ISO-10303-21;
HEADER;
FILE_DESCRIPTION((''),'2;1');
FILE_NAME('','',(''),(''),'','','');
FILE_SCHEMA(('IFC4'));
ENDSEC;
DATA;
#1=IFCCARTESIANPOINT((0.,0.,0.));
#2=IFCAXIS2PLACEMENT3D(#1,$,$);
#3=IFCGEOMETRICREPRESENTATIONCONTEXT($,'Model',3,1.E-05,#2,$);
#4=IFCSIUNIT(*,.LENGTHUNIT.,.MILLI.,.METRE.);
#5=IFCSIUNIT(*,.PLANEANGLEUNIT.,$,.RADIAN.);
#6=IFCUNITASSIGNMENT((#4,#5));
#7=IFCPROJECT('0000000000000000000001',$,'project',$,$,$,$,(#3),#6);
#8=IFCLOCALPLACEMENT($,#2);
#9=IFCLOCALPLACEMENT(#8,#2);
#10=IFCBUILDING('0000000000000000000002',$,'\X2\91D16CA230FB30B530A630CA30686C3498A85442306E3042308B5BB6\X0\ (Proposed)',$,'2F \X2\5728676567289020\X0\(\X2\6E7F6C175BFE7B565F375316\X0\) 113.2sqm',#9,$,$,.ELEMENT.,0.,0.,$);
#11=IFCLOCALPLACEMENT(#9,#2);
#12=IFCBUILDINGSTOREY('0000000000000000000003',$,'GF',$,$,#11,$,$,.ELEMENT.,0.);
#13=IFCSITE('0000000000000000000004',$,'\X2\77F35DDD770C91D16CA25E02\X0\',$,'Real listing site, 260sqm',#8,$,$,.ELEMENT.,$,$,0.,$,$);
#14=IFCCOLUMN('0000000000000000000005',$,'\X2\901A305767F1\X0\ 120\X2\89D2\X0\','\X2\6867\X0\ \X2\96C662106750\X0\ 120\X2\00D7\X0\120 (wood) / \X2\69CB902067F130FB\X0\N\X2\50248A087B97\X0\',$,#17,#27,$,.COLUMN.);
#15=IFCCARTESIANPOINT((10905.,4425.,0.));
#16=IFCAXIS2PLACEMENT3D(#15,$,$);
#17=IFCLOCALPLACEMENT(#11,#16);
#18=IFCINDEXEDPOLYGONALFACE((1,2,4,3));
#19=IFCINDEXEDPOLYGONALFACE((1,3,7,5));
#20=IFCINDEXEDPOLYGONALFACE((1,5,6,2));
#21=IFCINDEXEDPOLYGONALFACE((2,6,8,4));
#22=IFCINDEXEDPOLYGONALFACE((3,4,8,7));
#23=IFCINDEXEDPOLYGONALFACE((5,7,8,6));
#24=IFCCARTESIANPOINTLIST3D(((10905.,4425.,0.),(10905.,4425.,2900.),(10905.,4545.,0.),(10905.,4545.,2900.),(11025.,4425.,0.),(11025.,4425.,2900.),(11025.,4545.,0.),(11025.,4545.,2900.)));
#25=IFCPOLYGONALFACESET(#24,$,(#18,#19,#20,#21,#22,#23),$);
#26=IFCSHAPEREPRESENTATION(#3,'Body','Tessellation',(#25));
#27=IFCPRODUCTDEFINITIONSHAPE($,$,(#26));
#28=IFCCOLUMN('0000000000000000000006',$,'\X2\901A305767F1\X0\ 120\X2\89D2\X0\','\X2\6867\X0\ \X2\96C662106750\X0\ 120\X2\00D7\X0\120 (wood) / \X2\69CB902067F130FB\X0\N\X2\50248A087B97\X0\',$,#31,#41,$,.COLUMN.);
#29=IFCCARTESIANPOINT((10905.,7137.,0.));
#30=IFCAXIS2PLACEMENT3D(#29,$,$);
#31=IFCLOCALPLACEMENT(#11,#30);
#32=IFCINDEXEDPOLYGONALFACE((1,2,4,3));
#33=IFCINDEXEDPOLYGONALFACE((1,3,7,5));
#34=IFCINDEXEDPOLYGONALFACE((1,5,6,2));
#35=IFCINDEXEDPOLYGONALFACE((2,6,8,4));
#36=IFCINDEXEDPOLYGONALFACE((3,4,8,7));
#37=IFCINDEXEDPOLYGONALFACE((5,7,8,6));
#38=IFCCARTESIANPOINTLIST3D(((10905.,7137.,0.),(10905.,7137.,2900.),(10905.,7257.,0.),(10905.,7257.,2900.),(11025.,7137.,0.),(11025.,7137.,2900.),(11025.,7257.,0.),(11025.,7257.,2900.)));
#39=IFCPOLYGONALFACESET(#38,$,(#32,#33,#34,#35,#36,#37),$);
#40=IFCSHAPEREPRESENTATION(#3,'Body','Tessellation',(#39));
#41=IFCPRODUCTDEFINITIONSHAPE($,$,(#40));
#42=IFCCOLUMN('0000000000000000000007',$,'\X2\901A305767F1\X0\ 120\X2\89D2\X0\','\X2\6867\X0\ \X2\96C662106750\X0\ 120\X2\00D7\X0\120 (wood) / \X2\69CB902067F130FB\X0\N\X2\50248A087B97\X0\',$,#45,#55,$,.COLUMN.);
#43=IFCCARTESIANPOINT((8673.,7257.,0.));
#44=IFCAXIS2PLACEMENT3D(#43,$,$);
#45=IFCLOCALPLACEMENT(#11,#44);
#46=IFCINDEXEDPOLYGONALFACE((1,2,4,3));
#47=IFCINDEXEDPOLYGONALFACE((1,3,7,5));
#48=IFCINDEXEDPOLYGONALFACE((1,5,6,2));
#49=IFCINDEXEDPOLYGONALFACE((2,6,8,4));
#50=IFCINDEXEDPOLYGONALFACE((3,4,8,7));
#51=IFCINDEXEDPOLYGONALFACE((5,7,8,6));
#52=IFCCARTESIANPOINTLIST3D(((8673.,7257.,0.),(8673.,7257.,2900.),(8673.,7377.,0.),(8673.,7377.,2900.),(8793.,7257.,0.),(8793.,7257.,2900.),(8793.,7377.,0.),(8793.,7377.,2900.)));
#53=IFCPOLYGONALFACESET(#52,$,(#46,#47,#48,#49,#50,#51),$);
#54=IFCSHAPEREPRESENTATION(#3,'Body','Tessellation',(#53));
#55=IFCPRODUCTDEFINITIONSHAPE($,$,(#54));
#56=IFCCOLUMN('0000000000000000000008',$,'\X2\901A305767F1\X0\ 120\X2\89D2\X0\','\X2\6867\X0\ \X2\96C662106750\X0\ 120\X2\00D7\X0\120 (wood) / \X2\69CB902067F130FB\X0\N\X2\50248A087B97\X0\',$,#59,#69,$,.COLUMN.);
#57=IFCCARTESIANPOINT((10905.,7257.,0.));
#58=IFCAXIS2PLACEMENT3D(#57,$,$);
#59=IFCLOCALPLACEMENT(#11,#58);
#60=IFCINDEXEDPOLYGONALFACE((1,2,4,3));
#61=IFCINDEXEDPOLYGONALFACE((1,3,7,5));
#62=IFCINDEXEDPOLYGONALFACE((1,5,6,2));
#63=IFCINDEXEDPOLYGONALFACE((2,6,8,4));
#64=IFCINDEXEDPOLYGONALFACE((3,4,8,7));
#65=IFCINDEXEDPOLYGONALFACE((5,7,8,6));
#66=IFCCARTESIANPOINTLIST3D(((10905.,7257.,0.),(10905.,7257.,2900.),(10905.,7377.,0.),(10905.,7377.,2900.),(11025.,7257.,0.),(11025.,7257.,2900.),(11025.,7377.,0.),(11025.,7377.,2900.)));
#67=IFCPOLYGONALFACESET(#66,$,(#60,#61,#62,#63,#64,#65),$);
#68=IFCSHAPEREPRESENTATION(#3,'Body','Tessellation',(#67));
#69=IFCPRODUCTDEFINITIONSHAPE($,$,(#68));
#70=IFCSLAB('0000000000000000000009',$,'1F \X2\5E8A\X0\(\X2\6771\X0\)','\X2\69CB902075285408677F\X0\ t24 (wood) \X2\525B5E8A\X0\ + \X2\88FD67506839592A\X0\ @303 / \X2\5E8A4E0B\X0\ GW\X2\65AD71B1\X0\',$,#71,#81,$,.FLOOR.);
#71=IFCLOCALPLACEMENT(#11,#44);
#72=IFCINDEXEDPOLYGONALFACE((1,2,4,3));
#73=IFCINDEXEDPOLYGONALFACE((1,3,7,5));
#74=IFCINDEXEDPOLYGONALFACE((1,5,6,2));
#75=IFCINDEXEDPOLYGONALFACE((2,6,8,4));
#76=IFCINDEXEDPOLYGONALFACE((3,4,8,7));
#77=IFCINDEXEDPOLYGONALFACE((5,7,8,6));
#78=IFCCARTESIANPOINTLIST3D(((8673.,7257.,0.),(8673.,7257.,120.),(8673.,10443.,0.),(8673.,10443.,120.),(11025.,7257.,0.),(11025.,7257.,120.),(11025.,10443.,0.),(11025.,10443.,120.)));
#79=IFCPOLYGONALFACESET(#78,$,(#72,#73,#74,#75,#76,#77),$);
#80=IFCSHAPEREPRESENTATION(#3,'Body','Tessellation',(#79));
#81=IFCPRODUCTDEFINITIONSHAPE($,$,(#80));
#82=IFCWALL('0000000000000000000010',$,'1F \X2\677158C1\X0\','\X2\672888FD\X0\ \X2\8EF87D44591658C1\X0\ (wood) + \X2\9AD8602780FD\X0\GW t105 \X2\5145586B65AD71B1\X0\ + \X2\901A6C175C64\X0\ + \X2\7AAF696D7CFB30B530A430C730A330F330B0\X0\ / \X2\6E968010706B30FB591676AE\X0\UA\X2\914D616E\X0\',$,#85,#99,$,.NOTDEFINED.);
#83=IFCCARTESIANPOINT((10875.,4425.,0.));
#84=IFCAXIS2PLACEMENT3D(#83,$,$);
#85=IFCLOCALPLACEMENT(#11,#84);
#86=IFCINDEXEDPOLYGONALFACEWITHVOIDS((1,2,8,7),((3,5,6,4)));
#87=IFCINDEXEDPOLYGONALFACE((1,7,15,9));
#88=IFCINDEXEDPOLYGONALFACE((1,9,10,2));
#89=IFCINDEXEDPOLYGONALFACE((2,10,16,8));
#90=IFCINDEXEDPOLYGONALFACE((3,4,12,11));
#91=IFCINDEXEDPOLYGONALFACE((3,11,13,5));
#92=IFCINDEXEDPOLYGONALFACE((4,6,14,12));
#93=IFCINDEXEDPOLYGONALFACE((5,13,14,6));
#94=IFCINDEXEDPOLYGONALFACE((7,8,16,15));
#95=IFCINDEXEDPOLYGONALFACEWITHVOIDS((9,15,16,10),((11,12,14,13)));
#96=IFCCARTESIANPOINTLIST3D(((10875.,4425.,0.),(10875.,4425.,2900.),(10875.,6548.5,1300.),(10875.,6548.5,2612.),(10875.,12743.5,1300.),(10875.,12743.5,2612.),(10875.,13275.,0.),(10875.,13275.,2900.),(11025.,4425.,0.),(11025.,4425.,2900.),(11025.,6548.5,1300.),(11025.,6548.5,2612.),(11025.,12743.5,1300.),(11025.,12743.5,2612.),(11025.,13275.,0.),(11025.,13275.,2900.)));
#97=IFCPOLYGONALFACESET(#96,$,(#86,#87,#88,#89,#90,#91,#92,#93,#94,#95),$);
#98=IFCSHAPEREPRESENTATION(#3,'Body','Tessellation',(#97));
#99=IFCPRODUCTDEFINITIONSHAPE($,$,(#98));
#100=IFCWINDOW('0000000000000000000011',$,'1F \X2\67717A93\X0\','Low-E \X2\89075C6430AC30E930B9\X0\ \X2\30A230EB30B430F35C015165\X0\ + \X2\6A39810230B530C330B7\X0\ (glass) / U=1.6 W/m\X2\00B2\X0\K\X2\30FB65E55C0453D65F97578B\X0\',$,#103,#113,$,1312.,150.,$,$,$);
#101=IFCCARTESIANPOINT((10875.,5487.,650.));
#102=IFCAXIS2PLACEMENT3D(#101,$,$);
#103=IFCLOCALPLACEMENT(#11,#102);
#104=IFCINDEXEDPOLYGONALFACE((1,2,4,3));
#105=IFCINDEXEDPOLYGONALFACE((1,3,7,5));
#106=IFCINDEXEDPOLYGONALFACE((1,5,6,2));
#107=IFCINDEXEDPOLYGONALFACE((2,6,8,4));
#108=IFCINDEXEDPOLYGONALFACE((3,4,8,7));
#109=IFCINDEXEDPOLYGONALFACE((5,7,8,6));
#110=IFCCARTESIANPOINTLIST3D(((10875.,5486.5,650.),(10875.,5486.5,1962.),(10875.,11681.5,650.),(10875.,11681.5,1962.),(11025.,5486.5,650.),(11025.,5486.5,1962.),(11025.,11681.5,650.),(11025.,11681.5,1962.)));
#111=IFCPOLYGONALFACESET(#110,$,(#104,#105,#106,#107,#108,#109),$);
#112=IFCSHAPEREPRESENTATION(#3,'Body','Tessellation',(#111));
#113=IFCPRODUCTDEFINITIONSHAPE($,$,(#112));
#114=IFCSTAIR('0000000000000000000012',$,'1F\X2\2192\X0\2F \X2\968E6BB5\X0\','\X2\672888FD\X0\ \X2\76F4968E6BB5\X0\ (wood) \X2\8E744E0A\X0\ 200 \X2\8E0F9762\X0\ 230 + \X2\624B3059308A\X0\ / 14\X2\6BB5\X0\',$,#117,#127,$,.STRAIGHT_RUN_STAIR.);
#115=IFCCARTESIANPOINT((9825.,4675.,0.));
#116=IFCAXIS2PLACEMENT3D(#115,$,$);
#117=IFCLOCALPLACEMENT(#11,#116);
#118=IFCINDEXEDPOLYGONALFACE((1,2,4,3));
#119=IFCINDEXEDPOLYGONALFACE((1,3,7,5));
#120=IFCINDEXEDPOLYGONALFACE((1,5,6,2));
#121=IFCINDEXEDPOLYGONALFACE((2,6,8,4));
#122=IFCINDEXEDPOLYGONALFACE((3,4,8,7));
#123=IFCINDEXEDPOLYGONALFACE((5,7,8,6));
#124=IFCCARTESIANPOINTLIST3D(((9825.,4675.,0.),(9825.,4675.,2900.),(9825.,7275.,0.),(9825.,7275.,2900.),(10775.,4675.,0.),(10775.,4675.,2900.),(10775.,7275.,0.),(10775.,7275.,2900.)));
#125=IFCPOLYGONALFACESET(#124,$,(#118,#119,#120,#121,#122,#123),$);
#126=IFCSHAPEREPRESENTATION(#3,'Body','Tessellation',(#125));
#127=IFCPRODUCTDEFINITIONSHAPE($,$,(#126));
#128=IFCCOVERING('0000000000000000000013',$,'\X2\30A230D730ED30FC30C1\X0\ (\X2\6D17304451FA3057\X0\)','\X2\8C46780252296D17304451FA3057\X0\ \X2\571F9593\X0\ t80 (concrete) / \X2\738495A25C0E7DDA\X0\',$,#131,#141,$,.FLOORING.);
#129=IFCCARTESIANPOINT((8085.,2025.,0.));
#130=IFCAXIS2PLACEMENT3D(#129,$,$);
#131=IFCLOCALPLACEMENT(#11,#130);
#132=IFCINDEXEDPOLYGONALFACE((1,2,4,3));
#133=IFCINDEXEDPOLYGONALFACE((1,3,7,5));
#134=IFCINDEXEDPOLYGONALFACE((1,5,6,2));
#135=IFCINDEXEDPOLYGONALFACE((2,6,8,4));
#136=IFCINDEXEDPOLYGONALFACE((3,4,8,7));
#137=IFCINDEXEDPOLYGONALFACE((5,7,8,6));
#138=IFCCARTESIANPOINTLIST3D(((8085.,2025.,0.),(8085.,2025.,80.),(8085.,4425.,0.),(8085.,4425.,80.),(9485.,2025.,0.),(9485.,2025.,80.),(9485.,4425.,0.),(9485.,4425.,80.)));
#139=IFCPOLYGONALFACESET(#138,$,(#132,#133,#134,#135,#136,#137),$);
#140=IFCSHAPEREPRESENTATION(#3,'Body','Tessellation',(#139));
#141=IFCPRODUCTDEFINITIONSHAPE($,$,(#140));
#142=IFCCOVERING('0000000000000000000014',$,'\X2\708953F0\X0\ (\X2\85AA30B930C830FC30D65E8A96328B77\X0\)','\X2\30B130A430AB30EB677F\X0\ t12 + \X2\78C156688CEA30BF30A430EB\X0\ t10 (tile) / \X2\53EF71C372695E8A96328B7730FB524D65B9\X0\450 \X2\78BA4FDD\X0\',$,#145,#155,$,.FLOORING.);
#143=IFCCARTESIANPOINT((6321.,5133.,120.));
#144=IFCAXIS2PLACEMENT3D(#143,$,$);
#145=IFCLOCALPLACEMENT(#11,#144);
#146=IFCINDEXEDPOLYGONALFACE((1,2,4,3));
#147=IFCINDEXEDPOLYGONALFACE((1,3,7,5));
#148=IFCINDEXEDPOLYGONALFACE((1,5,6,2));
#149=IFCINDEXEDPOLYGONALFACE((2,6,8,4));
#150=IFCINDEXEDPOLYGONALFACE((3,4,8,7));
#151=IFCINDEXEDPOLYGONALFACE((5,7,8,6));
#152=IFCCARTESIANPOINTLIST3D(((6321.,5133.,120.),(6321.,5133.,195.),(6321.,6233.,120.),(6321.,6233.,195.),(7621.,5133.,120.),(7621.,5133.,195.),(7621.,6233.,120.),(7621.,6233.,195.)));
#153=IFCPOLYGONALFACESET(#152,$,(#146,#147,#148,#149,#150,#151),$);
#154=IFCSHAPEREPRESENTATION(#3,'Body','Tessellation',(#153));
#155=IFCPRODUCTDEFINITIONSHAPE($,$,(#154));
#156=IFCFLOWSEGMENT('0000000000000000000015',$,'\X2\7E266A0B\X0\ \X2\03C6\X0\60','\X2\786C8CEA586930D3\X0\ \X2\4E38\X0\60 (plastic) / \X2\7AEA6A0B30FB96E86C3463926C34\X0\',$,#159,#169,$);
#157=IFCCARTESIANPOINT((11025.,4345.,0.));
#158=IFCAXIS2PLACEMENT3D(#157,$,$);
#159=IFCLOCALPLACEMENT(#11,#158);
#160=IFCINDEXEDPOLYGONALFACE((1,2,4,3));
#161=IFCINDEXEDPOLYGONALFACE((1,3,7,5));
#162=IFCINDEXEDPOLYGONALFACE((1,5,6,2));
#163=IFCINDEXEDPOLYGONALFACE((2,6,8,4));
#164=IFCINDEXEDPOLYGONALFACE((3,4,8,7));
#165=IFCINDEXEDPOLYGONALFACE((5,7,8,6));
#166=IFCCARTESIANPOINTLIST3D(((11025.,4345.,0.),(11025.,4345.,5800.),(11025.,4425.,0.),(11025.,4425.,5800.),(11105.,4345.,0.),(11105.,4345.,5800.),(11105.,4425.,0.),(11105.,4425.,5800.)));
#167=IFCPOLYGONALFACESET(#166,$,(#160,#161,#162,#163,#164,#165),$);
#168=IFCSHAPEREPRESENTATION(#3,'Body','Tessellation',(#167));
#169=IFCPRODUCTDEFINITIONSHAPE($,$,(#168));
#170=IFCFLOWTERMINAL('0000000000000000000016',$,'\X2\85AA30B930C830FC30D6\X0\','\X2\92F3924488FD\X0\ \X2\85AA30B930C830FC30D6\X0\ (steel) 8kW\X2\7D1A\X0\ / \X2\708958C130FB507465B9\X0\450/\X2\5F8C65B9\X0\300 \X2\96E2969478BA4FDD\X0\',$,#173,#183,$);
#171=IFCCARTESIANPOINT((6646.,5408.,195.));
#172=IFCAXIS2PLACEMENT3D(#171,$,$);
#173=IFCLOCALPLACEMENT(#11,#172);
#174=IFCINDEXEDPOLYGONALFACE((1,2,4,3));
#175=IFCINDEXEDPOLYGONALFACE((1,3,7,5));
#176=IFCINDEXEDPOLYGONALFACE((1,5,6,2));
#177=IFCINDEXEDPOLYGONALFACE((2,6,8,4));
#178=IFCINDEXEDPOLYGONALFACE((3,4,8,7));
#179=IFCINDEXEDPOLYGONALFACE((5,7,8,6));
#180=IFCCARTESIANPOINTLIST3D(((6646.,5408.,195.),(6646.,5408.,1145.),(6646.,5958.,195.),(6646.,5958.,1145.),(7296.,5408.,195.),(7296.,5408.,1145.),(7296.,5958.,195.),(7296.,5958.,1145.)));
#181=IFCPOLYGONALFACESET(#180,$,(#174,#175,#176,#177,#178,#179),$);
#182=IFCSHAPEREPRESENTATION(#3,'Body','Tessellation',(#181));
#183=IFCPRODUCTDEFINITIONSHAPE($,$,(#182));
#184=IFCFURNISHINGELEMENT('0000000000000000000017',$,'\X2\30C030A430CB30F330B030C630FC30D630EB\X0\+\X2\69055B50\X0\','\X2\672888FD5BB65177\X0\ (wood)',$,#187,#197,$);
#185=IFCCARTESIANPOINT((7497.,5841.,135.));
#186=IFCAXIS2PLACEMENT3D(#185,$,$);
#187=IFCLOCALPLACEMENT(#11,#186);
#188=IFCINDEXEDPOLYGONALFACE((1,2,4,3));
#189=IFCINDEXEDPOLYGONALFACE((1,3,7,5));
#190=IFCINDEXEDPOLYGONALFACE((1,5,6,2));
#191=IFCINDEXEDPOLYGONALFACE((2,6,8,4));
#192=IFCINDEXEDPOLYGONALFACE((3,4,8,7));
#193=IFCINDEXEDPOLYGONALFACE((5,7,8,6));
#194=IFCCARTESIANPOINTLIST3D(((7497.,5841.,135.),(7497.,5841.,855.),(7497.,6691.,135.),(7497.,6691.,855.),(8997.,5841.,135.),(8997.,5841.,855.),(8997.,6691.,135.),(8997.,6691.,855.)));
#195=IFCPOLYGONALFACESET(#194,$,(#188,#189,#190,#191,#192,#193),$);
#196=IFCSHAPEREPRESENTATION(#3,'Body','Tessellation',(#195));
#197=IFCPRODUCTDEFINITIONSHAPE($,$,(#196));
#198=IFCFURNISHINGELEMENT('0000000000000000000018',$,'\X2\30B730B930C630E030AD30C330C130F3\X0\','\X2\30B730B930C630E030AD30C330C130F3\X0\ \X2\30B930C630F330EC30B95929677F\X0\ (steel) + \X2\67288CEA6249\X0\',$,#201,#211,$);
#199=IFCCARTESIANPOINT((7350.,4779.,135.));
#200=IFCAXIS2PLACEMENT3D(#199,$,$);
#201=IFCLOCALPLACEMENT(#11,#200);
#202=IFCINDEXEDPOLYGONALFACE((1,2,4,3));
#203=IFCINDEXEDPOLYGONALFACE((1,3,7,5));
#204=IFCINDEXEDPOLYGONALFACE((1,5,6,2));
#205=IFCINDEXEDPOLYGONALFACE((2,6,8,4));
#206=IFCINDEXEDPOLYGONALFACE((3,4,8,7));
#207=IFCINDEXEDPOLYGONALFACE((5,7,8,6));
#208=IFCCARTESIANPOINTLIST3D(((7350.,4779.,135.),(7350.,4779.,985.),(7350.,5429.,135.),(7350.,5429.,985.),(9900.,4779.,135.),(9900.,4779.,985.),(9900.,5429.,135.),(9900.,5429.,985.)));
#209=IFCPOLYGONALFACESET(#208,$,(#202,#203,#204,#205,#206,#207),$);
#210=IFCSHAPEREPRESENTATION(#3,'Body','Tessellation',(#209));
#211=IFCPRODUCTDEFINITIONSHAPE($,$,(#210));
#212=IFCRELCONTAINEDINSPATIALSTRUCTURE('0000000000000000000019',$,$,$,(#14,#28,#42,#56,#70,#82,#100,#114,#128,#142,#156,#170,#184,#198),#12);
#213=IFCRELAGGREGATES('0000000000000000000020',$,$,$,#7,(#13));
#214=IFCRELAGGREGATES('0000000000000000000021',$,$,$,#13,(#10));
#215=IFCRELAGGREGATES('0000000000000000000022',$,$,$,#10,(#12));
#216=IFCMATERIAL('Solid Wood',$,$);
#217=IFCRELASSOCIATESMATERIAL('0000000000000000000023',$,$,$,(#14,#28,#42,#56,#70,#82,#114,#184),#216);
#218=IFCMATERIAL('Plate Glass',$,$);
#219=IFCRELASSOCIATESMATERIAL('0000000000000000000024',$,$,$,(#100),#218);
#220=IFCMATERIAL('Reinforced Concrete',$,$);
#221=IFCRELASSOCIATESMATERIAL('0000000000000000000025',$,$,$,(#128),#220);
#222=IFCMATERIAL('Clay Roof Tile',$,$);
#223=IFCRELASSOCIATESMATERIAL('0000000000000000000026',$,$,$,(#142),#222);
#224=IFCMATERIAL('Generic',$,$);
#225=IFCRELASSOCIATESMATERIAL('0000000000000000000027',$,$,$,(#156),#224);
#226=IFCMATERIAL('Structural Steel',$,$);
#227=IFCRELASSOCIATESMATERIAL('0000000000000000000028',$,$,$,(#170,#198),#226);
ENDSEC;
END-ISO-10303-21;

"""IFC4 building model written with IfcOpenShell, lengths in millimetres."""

from ifc_helpers import new_model, si_unit, frame, frame_2d, origin, place, context, project, spatial, rectangle, extrude, material, element, fill, save


model = new_model("IFC4")

# Units and contexts
model_context = context("Model", 3, precision=1e-05, world=origin())
ifc_project = project(units=[si_unit("LENGTHUNIT", "METRE", prefix="MILLI"), si_unit("PLANEANGLEUNIT", "RADIAN")], contexts=[model_context])

# Site, building, storey
site_placement = place(None, origin())
site = spatial("IfcSite", under=ifc_project, at=site_placement, Name="石川県金沢市", ObjectType="Real listing site, 260sqm", CompositionType="ELEMENT", RefElevation=0.0)
building_placement = place(site_placement, origin())
building = spatial("IfcBuilding", under=site, at=building_placement, Name="金沢・サウナと水風呂のある家 (Proposed)", ObjectType="2F 在来木造(湿気対策強化) 113.2sqm", CompositionType="ELEMENT", ElevationOfRefHeight=0.0, ElevationOfTerrain=0.0)
storey_placement = place(building_placement, origin())
storey = spatial("IfcBuildingStorey", under=building, at=storey_placement, Name="GF", CompositionType="ELEMENT", Elevation=0.0)

# Columns
ifc_material_1 = material(Name="Solid Wood")
column_1_placement = place(storey_placement, frame((10905.0, 4425.0, 0.0)))
element("IfcColumn", 1, at=column_1_placement, inside=storey, material=ifc_material_1, Name="通し柱 120角", Description="桧 集成材 120×120 (wood) / 構造柱・N値計算", PredefinedType="COLUMN", context=model_context, shape_type="SweptSolid", body=[
    extrude(rectangle(XDim=120.0, YDim=120.0, at=frame_2d((60.0, 60.0))), frame((10905.0, 4425.0, 0.0)), (0.0, 0.0, 1.0), 2900.0),
])
column_2_placement = place(storey_placement, frame((10905.0, 7137.0, 0.0)))
element("IfcColumn", 2, at=column_2_placement, inside=storey, material=ifc_material_1, Name="通し柱 120角", Description="桧 集成材 120×120 (wood) / 構造柱・N値計算", PredefinedType="COLUMN", context=model_context, shape_type="SweptSolid", body=[
    extrude(rectangle(XDim=120.0, YDim=120.0, at=frame_2d((60.0, 60.0))), frame((10905.0, 7137.0, 0.0)), (0.0, 0.0, 1.0), 2900.0),
])
column_3_placement = place(storey_placement, frame((8673.0, 7257.0, 0.0)))
element("IfcColumn", 3, at=column_3_placement, inside=storey, material=ifc_material_1, Name="通し柱 120角", Description="桧 集成材 120×120 (wood) / 構造柱・N値計算", PredefinedType="COLUMN", context=model_context, shape_type="SweptSolid", body=[
    extrude(rectangle(XDim=120.0, YDim=120.0, at=frame_2d((60.0, 60.0))), frame((8673.0, 7257.0, 0.0)), (0.0, 0.0, 1.0), 2900.0),
])
column_4_placement = place(storey_placement, frame((10905.0, 7257.0, 0.0)))
element("IfcColumn", 4, at=column_4_placement, inside=storey, material=ifc_material_1, Name="通し柱 120角", Description="桧 集成材 120×120 (wood) / 構造柱・N値計算", PredefinedType="COLUMN", context=model_context, shape_type="SweptSolid", body=[
    extrude(rectangle(XDim=120.0, YDim=120.0, at=frame_2d((60.0, 60.0))), frame((10905.0, 7257.0, 0.0)), (0.0, 0.0, 1.0), 2900.0),
])

# Slab
slab_placement = place(storey_placement, frame((8673.0, 7257.0, 0.0)))
element("IfcSlab", 5, at=slab_placement, inside=storey, material=ifc_material_1, Name="1F 床(東)", Description="構造用合板 t24 (wood) 剛床 + 製材根太 @303 / 床下 GW断熱", PredefinedType="FLOOR", context=model_context, shape_type="SweptSolid", body=[
    extrude(rectangle(XDim=2352.0, YDim=3186.0, at=frame_2d((1176.0, 1593.0))), frame((8673.0, 7257.0, 0.0)), (0.0, 0.0, 1.0), 120.0),
])

# Wall, opening, window
wall_1_placement = place(storey_placement, frame((10875.0, 4425.0, 0.0)))
wall_1 = element("IfcWall", 6, at=wall_1_placement, inside=storey, material=ifc_material_1, Name="1F 東壁", Description="木製 軸組外壁 (wood) + 高性能GW t105 充填断熱 + 通気層 + 窯業系サイディング / 準耐火・外皮UA配慮", PredefinedType="NOTDEFINED", context=model_context, shape_type="SweptSolid", body=[
    extrude(rectangle(XDim=150.0, YDim=8850.0, at=frame_2d((75.0, 4425.0))), frame((10875.0, 4425.0, 0.0)), (0.0, 0.0, 1.0), 2900.0),
])
opening_placement = place(storey_placement, frame((10875.0, 5487.0, 650.0)))
opening = element("IfcOpeningElement", 7, at=opening_placement, cuts=wall_1, PredefinedType="NOTDEFINED", context=model_context, shape_type="SweptSolid", body=[
    extrude(rectangle(XDim=150.0, YDim=6195.0, at=frame_2d((75.0, 3097.0))), frame((10875.0, 5487.0, 650.0)), (0.0, 0.0, 1.0), 1312.0),
])
ifc_material_2 = material(Name="Plate Glass")
window_placement = place(storey_placement, frame((10875.0, 5487.0, 650.0)))
window = element("IfcWindow", 8, at=window_placement, inside=storey, material=ifc_material_2, Name="1F 東窓", Description="Low-E 複層ガラス アルゴン封入 + 樹脂サッシ (glass) / U=1.6 W/m²K・日射取得型", OverallHeight=1312.0, OverallWidth=150.0, context=model_context, shape_type="SweptSolid", body=[
    extrude(rectangle(XDim=150.0, YDim=6195.0, at=frame_2d((75.0, 3097.0))), frame((10875.0, 5487.0, 650.0)), (0.0, 0.0, 1.0), 1312.0),
])
fill(opening, window)

# Stair
stair_placement = place(storey_placement, frame((9825.0, 4675.0, 0.0)))
element("IfcStair", 9, at=stair_placement, inside=storey, material=ifc_material_1, Name="1F→2F 階段", Description="木製 直階段 (wood) 蹴上 200 踏面 230 + 手すり / 14段", PredefinedType="STRAIGHT_RUN_STAIR", context=model_context, shape_type="SweptSolid", body=[
    extrude(rectangle(XDim=950.0, YDim=2600.0, at=frame_2d((475.0, 1300.0))), frame((9825.0, 4675.0, 0.0)), (0.0, 0.0, 1.0), 2900.0),
])

# Coverings
ifc_material_3 = material(Name="Reinforced Concrete")
covering_1_placement = place(storey_placement, frame((8085.0, 2025.0, 0.0)))
element("IfcCovering", 10, at=covering_1_placement, inside=storey, material=ifc_material_3, Name="アプローチ (洗い出し)", Description="豆砂利洗い出し 土間 t80 (concrete) / 玄関導線", PredefinedType="FLOORING", context=model_context, shape_type="SweptSolid", body=[
    extrude(rectangle(XDim=1400.0, YDim=2400.0, at=frame_2d((700.0, 1200.0))), frame((8085.0, 2025.0, 0.0)), (0.0, 0.0, 1.0), 80.0),
])
ifc_material_4 = material(Name="Clay Roof Tile")
covering_2_placement = place(storey_placement, frame((6321.0, 5133.0, 120.0)))
element("IfcCovering", 11, at=covering_2_placement, inside=storey, material=ifc_material_4, Name="炉台 (薪ストーブ床防護)", Description="ケイカル板 t12 + 磁器質タイル t10 (tile) / 可燃物床防護・前方450 確保", PredefinedType="FLOORING", context=model_context, shape_type="SweptSolid", body=[
    extrude(rectangle(XDim=1300.0, YDim=1100.0, at=frame_2d((650.0, 550.0))), frame((6321.0, 5133.0, 120.0)), (0.0, 0.0, 1.0), 75.0),
])

# Flow segment
ifc_material_5 = material(Name="Generic")
flow_segment_placement = place(storey_placement, frame((11025.0, 4345.0, 0.0)))
element("IfcFlowSegment", 12, at=flow_segment_placement, inside=storey, material=ifc_material_5, Name="縦樋 φ60", Description="硬質塩ビ 丸60 (plastic) / 竪樋・雨水排水", context=model_context, shape_type="SweptSolid", body=[
    extrude(rectangle(XDim=80.0, YDim=80.0, at=frame_2d((40.0, 40.0))), frame((11025.0, 4345.0, 0.0)), (0.0, 0.0, 1.0), 5800.0),
])

# Flow terminal
ifc_material_6 = material(Name="Structural Steel")
flow_terminal_placement = place(storey_placement, frame((6646.0, 5408.0, 195.0)))
element("IfcFlowTerminal", 13, at=flow_terminal_placement, inside=storey, material=ifc_material_6, Name="薪ストーブ", Description="鋳鉄製 薪ストーブ (steel) 8kW級 / 炉壁・側方450/後方300 離隔確保", context=model_context, shape_type="SweptSolid", body=[
    extrude(rectangle(XDim=650.0, YDim=550.0, at=frame_2d((325.0, 275.0))), frame((6646.0, 5408.0, 195.0)), (0.0, 0.0, 1.0), 950.0),
])

# Furnishing elements
furnishing_1_placement = place(storey_placement, frame((7497.0, 5841.0, 135.0)))
element("IfcFurnishingElement", 14, at=furnishing_1_placement, inside=storey, material=ifc_material_1, Name="ダイニングテーブル+椅子", Description="木製家具 (wood)", context=model_context, shape_type="SweptSolid", body=[
    extrude(rectangle(XDim=1500.0, YDim=850.0, at=frame_2d((750.0, 425.0))), frame((7497.0, 5841.0, 135.0)), (0.0, 0.0, 1.0), 720.0),
])
furnishing_2_placement = place(storey_placement, frame((7350.0, 4779.0, 135.0)))
element("IfcFurnishingElement", 15, at=furnishing_2_placement, inside=storey, material=ifc_material_6, Name="システムキッチン", Description="システムキッチン ステンレス天板 (steel) + 木質扉", context=model_context, shape_type="SweptSolid", body=[
    extrude(rectangle(XDim=2550.0, YDim=650.0, at=frame_2d((1275.0, 325.0))), frame((7350.0, 4779.0, 135.0)), (0.0, 0.0, 1.0), 850.0),
])

save(model, "model.ifc")
